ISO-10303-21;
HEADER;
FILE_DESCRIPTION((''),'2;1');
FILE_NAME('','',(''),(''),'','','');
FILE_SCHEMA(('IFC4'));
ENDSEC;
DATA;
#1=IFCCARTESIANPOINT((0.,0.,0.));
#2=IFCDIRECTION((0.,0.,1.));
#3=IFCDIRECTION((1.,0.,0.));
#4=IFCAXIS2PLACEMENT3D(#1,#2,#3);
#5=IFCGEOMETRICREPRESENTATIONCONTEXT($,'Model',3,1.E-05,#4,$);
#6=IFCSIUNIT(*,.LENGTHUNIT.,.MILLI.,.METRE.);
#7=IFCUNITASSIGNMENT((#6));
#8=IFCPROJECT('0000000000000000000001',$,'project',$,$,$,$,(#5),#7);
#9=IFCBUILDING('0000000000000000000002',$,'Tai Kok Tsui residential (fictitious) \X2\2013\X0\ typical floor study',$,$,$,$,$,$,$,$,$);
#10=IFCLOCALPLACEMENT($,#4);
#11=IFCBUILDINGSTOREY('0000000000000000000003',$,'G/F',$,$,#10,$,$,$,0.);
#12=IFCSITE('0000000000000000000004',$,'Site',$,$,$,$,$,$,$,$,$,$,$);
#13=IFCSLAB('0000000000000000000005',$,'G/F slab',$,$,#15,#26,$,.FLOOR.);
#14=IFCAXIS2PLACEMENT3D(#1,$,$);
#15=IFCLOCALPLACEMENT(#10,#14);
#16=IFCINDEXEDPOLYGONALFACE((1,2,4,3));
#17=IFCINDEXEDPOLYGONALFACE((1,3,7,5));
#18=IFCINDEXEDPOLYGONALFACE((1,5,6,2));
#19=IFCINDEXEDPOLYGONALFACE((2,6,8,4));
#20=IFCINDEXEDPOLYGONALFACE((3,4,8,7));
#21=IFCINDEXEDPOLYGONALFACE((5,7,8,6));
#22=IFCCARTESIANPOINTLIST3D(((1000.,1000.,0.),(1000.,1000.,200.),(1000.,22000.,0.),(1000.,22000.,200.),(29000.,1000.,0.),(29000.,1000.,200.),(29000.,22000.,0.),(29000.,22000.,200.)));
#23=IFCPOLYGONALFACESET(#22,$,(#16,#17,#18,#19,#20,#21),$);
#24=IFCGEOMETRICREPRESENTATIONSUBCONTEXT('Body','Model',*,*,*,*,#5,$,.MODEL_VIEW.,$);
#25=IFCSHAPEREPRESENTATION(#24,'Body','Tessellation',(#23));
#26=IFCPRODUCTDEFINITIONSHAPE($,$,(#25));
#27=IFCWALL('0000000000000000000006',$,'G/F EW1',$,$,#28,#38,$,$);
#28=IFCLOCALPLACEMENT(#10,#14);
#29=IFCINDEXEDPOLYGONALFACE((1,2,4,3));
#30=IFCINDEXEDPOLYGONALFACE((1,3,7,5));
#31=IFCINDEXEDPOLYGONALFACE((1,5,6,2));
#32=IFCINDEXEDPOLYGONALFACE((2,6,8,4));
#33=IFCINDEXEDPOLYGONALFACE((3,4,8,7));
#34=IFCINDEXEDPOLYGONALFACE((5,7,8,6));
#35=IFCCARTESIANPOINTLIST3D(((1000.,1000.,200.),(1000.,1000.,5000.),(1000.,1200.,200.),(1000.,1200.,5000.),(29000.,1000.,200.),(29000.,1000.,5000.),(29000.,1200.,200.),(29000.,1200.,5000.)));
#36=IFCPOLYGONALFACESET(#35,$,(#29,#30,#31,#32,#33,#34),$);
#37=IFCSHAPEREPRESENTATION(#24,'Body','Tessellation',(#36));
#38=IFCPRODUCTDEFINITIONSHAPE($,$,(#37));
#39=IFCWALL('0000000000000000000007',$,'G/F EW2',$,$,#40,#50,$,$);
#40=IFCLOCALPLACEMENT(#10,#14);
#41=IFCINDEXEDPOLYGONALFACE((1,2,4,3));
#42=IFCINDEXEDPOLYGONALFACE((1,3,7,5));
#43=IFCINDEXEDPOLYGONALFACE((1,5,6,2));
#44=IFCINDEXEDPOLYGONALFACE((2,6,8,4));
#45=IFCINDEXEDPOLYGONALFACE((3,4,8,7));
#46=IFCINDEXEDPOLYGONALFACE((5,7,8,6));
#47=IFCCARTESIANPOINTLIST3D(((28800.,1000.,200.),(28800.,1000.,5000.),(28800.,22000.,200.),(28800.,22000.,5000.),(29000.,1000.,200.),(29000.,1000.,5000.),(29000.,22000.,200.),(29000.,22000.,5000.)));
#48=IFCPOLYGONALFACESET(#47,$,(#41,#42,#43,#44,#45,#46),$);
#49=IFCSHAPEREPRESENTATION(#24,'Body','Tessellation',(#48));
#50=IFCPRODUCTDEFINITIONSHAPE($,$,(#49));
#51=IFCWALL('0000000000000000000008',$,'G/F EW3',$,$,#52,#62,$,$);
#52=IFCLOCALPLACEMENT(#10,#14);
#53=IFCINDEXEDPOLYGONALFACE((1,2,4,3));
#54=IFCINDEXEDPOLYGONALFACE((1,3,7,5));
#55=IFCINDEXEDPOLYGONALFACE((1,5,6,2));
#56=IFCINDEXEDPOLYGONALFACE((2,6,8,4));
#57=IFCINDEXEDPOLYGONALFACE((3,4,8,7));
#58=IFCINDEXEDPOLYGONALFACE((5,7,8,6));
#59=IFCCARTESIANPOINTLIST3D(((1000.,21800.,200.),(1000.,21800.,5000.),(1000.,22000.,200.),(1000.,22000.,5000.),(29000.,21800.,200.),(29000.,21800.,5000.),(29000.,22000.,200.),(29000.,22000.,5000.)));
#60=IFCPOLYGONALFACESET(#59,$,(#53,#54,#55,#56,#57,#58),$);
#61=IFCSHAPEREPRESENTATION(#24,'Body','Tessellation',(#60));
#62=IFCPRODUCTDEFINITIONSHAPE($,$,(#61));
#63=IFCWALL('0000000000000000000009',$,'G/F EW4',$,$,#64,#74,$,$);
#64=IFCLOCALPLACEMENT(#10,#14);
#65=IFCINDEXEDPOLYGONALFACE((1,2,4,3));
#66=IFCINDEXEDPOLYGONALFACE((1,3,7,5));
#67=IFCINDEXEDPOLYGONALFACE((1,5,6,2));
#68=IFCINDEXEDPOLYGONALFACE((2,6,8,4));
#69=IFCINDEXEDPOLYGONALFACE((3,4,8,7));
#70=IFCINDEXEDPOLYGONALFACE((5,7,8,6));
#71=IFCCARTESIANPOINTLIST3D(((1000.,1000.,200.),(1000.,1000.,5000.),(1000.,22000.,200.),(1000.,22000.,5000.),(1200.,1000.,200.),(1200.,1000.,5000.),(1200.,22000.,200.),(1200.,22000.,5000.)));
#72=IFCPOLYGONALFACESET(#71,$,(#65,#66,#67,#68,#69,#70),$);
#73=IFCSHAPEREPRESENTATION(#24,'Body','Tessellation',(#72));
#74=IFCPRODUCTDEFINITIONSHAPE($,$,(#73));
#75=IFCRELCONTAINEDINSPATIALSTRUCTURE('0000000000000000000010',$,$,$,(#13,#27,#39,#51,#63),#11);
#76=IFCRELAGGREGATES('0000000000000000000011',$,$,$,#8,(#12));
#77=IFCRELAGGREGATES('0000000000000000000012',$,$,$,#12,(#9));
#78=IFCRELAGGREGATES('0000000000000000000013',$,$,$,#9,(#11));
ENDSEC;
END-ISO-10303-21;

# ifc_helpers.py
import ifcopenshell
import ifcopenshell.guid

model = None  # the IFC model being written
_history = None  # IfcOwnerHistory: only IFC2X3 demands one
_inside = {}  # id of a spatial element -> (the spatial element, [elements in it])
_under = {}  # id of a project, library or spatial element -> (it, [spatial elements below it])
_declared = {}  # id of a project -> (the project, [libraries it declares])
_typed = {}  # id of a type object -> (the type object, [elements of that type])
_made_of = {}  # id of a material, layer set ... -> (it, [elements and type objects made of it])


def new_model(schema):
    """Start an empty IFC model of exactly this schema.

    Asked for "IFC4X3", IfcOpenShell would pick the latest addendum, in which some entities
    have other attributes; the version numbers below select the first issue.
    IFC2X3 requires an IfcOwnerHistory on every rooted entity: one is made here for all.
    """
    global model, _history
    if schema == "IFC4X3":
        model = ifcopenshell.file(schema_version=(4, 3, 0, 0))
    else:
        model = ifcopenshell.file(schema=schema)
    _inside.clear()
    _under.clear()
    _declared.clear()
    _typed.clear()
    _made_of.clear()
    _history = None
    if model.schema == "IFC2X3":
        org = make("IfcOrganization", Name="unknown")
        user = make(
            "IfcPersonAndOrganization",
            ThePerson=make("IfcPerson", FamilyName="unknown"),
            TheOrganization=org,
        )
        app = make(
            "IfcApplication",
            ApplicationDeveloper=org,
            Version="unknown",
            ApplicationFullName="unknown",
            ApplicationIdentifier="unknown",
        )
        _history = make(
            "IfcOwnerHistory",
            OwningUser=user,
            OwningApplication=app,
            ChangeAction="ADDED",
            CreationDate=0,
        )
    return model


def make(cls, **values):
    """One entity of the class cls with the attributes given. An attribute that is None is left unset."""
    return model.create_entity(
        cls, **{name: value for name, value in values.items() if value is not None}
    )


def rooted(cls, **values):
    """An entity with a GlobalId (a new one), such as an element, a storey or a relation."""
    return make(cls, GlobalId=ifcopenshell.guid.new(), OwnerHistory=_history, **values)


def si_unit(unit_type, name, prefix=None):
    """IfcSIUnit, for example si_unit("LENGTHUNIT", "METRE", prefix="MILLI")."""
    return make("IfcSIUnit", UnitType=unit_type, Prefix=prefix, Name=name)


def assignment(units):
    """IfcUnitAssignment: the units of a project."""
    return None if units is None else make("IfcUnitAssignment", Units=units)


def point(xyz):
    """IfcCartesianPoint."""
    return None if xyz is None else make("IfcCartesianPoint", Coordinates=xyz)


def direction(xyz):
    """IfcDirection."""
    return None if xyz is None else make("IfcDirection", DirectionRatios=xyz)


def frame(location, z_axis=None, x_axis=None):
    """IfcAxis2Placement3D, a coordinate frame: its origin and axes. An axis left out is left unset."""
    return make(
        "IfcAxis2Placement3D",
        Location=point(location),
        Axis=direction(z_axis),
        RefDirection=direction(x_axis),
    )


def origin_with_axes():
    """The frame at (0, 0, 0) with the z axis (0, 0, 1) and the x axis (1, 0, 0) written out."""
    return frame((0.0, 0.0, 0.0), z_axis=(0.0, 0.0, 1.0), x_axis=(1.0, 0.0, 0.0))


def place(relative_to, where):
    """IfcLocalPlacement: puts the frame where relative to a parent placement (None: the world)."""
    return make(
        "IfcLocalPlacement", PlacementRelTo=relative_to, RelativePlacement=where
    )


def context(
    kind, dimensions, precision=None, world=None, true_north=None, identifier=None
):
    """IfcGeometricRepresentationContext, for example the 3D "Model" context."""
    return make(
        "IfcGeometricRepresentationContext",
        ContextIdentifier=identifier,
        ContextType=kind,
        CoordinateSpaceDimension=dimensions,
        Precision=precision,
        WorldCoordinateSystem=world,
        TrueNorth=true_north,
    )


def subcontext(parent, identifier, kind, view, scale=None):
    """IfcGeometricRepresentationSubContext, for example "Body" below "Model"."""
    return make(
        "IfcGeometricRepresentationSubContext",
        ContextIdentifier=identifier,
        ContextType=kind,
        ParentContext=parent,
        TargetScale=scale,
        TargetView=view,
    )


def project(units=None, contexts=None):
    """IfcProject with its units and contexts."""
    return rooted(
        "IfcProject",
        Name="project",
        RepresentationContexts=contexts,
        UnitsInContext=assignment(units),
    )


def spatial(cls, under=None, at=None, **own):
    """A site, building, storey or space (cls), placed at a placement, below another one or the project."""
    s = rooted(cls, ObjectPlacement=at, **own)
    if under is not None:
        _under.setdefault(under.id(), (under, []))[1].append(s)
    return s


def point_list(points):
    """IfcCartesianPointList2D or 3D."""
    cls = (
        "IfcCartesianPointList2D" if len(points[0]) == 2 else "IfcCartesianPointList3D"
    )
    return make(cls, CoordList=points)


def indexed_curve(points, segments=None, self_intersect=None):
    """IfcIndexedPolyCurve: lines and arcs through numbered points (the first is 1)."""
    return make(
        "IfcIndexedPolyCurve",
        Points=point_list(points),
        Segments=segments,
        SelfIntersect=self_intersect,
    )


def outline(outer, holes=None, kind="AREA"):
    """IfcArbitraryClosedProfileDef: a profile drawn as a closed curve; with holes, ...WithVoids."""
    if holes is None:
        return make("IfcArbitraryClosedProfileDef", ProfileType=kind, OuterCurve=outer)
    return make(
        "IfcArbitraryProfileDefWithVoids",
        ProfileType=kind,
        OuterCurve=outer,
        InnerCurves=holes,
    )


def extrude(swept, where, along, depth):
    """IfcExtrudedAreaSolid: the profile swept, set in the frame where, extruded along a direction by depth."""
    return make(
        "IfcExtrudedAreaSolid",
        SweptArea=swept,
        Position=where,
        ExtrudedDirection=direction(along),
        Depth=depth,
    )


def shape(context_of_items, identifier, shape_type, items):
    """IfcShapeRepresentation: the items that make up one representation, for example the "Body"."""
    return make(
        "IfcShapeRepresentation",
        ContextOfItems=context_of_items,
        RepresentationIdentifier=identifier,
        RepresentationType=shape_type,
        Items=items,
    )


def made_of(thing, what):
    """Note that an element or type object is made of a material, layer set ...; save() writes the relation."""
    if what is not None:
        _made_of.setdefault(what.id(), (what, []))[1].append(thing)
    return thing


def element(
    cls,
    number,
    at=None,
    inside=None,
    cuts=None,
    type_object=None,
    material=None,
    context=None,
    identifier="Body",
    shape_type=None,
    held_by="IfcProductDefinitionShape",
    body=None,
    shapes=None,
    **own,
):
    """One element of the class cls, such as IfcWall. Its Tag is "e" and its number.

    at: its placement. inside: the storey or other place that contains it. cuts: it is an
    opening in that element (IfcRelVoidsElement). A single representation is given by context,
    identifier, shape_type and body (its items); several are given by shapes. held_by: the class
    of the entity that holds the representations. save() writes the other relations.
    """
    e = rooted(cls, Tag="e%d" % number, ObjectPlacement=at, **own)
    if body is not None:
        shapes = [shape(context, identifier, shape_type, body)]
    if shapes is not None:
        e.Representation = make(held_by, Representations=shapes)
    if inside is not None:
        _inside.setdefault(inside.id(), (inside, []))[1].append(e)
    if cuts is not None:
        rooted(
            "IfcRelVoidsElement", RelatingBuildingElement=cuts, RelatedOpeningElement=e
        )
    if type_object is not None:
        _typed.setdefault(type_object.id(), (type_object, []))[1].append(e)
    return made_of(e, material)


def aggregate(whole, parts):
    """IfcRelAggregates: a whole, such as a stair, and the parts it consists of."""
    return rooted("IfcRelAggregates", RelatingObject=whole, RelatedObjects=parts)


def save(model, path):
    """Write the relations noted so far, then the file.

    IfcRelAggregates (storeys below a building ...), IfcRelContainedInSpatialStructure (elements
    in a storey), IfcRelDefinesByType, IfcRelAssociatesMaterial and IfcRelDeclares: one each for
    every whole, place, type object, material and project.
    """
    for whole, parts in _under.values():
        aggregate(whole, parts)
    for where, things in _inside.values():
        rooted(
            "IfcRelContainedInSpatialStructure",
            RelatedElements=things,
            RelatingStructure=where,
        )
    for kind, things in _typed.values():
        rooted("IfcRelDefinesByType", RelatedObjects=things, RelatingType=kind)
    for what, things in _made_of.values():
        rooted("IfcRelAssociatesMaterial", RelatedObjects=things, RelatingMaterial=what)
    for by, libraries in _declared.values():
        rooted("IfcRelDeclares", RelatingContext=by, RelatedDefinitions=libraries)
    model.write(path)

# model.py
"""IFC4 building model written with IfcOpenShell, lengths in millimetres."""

from ifc_helpers import new_model, si_unit, frame, origin_with_axes, place, context, subcontext, project, spatial, indexed_curve, outline, extrude, element, save


model = new_model("IFC4")

# Units and contexts
model_context = context("Model", 3, precision=1e-05, world=origin_with_axes())
body_context = subcontext(model_context, "Body", "Model", "MODEL_VIEW")
ifc_project = project(units=[si_unit("LENGTHUNIT", "METRE", prefix="MILLI")], contexts=[model_context])

# Site, building, storey
site = spatial("IfcSite", under=ifc_project, Name="Site")
building = spatial("IfcBuilding", under=site, Name="Tai Kok Tsui residential (fictitious) – typical floor study")
storey_placement = place(None, origin_with_axes())
storey = spatial("IfcBuildingStorey", under=building, at=storey_placement, Name="G/F", Elevation=0.0)

# Slab
slab_placement = place(storey_placement, origin_with_axes())
element("IfcSlab", 1, at=slab_placement, inside=storey, Name="G/F slab", PredefinedType="FLOOR", context=body_context, shape_type="SweptSolid", body=[
    extrude(outline(indexed_curve([(1000.0, 1000.0), (29000.0, 1000.0), (29000.0, 22000.0), (1000.0, 22000.0)])), None, (0.0, 0.0, 1.0), 200.0),
])

# Walls
wall_1_placement = place(storey_placement, frame((1000.0, 1000.0, 200.0), z_axis=(0.0, 0.0, 1.0), x_axis=(1.0, 0.0, 0.0)))
element("IfcWall", 2, at=wall_1_placement, inside=storey, Name="G/F EW1", context=body_context, shape_type="SweptSolid", body=[
    extrude(outline(indexed_curve([(0.0, 0.0), (0.0, 200.0), (28000.0, 200.0), (28000.0, 0.0), (0.0, 0.0)], self_intersect=False)), origin_with_axes(), (0.0, 0.0, 1.0), 4800.0),
])
wall_2_placement = place(storey_placement, frame((29000.0, 1000.0, 200.0), z_axis=(0.0, 0.0, 1.0), x_axis=(0.0, 1.0, 0.0)))
element("IfcWall", 3, at=wall_2_placement, inside=storey, Name="G/F EW2", context=body_context, shape_type="SweptSolid", body=[
    extrude(outline(indexed_curve([(0.0, 0.0), (0.0, 200.0), (21000.0, 200.0), (21000.0, 0.0), (0.0, 0.0)], self_intersect=False)), origin_with_axes(), (0.0, 0.0, 1.0), 4800.0),
])
wall_3_placement = place(storey_placement, frame((29000.0, 22000.0, 200.0), z_axis=(0.0, 0.0, 1.0), x_axis=(-1.0, 0.0, 0.0)))
element("IfcWall", 4, at=wall_3_placement, inside=storey, Name="G/F EW3", context=body_context, shape_type="SweptSolid", body=[
    extrude(outline(indexed_curve([(0.0, 0.0), (0.0, 200.0), (28000.0, 200.0), (28000.0, 0.0), (0.0, 0.0)], self_intersect=False)), origin_with_axes(), (0.0, 0.0, 1.0), 4800.0),
])
wall_4_placement = place(storey_placement, frame((1000.0, 22000.0, 200.0), z_axis=(0.0, 0.0, 1.0), x_axis=(0.0, -1.0, 0.0)))
element("IfcWall", 5, at=wall_4_placement, inside=storey, Name="G/F EW4", context=body_context, shape_type="SweptSolid", body=[
    extrude(outline(indexed_curve([(0.0, 0.0), (0.0, 200.0), (21000.0, 200.0), (21000.0, 0.0), (0.0, 0.0)], self_intersect=False)), origin_with_axes(), (0.0, 0.0, 1.0), 4800.0),
])

save(model, "model.ifc")
